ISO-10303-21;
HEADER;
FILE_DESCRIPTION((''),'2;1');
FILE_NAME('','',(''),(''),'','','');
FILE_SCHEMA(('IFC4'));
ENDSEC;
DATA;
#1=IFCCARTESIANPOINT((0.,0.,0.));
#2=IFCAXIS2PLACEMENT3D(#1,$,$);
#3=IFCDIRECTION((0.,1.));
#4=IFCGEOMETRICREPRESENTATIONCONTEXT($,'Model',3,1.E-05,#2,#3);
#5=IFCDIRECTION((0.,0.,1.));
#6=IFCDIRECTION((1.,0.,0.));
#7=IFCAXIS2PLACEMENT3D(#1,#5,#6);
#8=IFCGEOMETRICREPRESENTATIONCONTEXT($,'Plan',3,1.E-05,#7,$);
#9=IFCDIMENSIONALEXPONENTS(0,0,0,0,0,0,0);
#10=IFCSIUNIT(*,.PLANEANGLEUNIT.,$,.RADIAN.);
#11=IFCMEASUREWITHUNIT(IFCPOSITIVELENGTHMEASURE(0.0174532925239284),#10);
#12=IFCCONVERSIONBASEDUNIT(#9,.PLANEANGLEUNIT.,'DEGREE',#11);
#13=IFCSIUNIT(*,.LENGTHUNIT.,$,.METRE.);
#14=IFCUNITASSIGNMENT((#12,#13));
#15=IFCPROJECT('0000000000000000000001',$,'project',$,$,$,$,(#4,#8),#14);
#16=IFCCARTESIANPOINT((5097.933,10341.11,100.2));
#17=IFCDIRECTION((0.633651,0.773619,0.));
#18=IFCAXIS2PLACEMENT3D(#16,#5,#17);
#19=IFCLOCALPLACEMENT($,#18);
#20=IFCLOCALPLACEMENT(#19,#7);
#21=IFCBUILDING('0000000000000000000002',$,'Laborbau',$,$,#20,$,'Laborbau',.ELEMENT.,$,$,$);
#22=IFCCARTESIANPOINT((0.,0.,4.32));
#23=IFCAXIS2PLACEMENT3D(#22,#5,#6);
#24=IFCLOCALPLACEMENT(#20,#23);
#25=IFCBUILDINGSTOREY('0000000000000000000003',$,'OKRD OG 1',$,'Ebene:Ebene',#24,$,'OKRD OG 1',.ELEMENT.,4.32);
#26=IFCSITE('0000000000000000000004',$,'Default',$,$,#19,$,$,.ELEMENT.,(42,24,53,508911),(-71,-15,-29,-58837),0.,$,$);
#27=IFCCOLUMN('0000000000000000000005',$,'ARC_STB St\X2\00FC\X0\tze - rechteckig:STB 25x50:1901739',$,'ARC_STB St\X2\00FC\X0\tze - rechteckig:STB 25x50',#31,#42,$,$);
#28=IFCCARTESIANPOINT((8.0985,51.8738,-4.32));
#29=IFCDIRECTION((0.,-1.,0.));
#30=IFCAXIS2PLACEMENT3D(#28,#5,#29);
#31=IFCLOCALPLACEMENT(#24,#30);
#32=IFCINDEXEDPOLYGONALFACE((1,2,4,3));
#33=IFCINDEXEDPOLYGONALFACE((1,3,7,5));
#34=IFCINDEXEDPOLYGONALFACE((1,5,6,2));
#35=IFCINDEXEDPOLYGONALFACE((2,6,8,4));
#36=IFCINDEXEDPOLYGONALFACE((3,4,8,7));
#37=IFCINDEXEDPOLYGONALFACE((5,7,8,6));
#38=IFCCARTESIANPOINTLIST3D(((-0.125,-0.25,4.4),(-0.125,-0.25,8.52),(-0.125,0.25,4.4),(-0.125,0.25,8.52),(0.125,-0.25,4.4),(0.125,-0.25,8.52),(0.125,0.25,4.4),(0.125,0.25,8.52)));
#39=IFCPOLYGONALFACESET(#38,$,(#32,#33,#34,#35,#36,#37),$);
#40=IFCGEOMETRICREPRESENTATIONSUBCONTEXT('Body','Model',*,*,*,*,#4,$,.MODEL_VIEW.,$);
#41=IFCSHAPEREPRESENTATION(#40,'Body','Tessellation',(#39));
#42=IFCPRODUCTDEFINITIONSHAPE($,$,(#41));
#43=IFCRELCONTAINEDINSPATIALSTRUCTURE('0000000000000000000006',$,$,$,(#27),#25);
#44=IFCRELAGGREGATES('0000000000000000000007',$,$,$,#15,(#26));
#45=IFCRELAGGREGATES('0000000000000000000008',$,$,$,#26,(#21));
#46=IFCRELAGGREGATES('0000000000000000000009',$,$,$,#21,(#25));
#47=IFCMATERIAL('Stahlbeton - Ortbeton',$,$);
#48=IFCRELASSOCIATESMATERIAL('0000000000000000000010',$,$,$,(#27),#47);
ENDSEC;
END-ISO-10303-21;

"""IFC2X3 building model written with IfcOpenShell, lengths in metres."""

from ifc_helpers import new_model, entity, si_unit, converted_unit, direction, frame, origin, origin_with_axes, origin_2d_with_axis, place, context, subcontext, project, spatial, rectangle, extrude, source, transform, mapped, material, element, save


model = new_model("IFC2X3")

# Units and contexts
model_context = context("Model", 3, precision=1e-05, world=origin(), true_north=direction((0.0, 1.0)))
plan_context = context("Plan", 3, precision=1e-05, world=origin_with_axes())
body_context = subcontext(model_context, "Body", "Model", "MODEL_VIEW")
ifc_project = project(units=[converted_unit("PLANEANGLEUNIT", "DEGREE", entity("IfcPositiveLengthMeasure", 0.0174532925239284), si_unit("PLANEANGLEUNIT", "RADIAN"), dimensions=[0, 0, 0, 0, 0, 0, 0]), si_unit("LENGTHUNIT", "METRE")], contexts=[model_context, plan_context])

# Site, building, storey
site_placement = place(None, frame((5097.933, 10341.11, 100.2), z_axis=(0.0, 0.0, 1.0), x_axis=(0.633651, 0.773619, 0.0)))
site = spatial("IfcSite", under=ifc_project, at=site_placement, Name="Default", CompositionType="ELEMENT", RefLatitude=(42, 24, 53, 508911), RefLongitude=(-71, -15, -29, -58837), RefElevation=0.0)
building_placement = place(site_placement, origin_with_axes())
building = spatial("IfcBuilding", under=site, at=building_placement, Name="Laborbau", LongName="Laborbau", CompositionType="ELEMENT")
storey_placement = place(building_placement, frame((0.0, 0.0, 4.32), z_axis=(0.0, 0.0, 1.0), x_axis=(1.0, 0.0, 0.0)))
storey = spatial("IfcBuildingStorey", under=building, at=storey_placement, Name="OKRD OG 1", ObjectType="Ebene:Ebene", LongName="OKRD OG 1", CompositionType="ELEMENT", Elevation=4.32)

# Column
ifc_material_1 = material(Name="Stahlbeton - Ortbeton")
shared_shape = source(origin(), body_context, "Body", "SweptSolid", [
    extrude(rectangle(XDim=0.5, YDim=0.25, at=origin_2d_with_axis()), frame((0.0, 0.0, 4.4), z_axis=(0.0, 0.0, 1.0), x_axis=(0.0, -1.0, 0.0)), (0.0, 0.0, 1.0), 4.12),
])
column_placement = place(storey_placement, frame((8.0985, 51.8738, -4.32), z_axis=(0.0, 0.0, 1.0), x_axis=(0.0, -1.0, 0.0)))
element("IfcColumn", 1, at=column_placement, inside=storey, material=ifc_material_1, Name="ARC_STB Stütze - rechteckig:STB 25x50:1901739", ObjectType="ARC_STB Stütze - rechteckig:STB 25x50", context=body_context, shape_type="MappedRepresentation", body=[
    mapped(shared_shape, transform((0.0, 0.0, 0.0), scale=1.0)),
])

save(model, "model.ifc")
